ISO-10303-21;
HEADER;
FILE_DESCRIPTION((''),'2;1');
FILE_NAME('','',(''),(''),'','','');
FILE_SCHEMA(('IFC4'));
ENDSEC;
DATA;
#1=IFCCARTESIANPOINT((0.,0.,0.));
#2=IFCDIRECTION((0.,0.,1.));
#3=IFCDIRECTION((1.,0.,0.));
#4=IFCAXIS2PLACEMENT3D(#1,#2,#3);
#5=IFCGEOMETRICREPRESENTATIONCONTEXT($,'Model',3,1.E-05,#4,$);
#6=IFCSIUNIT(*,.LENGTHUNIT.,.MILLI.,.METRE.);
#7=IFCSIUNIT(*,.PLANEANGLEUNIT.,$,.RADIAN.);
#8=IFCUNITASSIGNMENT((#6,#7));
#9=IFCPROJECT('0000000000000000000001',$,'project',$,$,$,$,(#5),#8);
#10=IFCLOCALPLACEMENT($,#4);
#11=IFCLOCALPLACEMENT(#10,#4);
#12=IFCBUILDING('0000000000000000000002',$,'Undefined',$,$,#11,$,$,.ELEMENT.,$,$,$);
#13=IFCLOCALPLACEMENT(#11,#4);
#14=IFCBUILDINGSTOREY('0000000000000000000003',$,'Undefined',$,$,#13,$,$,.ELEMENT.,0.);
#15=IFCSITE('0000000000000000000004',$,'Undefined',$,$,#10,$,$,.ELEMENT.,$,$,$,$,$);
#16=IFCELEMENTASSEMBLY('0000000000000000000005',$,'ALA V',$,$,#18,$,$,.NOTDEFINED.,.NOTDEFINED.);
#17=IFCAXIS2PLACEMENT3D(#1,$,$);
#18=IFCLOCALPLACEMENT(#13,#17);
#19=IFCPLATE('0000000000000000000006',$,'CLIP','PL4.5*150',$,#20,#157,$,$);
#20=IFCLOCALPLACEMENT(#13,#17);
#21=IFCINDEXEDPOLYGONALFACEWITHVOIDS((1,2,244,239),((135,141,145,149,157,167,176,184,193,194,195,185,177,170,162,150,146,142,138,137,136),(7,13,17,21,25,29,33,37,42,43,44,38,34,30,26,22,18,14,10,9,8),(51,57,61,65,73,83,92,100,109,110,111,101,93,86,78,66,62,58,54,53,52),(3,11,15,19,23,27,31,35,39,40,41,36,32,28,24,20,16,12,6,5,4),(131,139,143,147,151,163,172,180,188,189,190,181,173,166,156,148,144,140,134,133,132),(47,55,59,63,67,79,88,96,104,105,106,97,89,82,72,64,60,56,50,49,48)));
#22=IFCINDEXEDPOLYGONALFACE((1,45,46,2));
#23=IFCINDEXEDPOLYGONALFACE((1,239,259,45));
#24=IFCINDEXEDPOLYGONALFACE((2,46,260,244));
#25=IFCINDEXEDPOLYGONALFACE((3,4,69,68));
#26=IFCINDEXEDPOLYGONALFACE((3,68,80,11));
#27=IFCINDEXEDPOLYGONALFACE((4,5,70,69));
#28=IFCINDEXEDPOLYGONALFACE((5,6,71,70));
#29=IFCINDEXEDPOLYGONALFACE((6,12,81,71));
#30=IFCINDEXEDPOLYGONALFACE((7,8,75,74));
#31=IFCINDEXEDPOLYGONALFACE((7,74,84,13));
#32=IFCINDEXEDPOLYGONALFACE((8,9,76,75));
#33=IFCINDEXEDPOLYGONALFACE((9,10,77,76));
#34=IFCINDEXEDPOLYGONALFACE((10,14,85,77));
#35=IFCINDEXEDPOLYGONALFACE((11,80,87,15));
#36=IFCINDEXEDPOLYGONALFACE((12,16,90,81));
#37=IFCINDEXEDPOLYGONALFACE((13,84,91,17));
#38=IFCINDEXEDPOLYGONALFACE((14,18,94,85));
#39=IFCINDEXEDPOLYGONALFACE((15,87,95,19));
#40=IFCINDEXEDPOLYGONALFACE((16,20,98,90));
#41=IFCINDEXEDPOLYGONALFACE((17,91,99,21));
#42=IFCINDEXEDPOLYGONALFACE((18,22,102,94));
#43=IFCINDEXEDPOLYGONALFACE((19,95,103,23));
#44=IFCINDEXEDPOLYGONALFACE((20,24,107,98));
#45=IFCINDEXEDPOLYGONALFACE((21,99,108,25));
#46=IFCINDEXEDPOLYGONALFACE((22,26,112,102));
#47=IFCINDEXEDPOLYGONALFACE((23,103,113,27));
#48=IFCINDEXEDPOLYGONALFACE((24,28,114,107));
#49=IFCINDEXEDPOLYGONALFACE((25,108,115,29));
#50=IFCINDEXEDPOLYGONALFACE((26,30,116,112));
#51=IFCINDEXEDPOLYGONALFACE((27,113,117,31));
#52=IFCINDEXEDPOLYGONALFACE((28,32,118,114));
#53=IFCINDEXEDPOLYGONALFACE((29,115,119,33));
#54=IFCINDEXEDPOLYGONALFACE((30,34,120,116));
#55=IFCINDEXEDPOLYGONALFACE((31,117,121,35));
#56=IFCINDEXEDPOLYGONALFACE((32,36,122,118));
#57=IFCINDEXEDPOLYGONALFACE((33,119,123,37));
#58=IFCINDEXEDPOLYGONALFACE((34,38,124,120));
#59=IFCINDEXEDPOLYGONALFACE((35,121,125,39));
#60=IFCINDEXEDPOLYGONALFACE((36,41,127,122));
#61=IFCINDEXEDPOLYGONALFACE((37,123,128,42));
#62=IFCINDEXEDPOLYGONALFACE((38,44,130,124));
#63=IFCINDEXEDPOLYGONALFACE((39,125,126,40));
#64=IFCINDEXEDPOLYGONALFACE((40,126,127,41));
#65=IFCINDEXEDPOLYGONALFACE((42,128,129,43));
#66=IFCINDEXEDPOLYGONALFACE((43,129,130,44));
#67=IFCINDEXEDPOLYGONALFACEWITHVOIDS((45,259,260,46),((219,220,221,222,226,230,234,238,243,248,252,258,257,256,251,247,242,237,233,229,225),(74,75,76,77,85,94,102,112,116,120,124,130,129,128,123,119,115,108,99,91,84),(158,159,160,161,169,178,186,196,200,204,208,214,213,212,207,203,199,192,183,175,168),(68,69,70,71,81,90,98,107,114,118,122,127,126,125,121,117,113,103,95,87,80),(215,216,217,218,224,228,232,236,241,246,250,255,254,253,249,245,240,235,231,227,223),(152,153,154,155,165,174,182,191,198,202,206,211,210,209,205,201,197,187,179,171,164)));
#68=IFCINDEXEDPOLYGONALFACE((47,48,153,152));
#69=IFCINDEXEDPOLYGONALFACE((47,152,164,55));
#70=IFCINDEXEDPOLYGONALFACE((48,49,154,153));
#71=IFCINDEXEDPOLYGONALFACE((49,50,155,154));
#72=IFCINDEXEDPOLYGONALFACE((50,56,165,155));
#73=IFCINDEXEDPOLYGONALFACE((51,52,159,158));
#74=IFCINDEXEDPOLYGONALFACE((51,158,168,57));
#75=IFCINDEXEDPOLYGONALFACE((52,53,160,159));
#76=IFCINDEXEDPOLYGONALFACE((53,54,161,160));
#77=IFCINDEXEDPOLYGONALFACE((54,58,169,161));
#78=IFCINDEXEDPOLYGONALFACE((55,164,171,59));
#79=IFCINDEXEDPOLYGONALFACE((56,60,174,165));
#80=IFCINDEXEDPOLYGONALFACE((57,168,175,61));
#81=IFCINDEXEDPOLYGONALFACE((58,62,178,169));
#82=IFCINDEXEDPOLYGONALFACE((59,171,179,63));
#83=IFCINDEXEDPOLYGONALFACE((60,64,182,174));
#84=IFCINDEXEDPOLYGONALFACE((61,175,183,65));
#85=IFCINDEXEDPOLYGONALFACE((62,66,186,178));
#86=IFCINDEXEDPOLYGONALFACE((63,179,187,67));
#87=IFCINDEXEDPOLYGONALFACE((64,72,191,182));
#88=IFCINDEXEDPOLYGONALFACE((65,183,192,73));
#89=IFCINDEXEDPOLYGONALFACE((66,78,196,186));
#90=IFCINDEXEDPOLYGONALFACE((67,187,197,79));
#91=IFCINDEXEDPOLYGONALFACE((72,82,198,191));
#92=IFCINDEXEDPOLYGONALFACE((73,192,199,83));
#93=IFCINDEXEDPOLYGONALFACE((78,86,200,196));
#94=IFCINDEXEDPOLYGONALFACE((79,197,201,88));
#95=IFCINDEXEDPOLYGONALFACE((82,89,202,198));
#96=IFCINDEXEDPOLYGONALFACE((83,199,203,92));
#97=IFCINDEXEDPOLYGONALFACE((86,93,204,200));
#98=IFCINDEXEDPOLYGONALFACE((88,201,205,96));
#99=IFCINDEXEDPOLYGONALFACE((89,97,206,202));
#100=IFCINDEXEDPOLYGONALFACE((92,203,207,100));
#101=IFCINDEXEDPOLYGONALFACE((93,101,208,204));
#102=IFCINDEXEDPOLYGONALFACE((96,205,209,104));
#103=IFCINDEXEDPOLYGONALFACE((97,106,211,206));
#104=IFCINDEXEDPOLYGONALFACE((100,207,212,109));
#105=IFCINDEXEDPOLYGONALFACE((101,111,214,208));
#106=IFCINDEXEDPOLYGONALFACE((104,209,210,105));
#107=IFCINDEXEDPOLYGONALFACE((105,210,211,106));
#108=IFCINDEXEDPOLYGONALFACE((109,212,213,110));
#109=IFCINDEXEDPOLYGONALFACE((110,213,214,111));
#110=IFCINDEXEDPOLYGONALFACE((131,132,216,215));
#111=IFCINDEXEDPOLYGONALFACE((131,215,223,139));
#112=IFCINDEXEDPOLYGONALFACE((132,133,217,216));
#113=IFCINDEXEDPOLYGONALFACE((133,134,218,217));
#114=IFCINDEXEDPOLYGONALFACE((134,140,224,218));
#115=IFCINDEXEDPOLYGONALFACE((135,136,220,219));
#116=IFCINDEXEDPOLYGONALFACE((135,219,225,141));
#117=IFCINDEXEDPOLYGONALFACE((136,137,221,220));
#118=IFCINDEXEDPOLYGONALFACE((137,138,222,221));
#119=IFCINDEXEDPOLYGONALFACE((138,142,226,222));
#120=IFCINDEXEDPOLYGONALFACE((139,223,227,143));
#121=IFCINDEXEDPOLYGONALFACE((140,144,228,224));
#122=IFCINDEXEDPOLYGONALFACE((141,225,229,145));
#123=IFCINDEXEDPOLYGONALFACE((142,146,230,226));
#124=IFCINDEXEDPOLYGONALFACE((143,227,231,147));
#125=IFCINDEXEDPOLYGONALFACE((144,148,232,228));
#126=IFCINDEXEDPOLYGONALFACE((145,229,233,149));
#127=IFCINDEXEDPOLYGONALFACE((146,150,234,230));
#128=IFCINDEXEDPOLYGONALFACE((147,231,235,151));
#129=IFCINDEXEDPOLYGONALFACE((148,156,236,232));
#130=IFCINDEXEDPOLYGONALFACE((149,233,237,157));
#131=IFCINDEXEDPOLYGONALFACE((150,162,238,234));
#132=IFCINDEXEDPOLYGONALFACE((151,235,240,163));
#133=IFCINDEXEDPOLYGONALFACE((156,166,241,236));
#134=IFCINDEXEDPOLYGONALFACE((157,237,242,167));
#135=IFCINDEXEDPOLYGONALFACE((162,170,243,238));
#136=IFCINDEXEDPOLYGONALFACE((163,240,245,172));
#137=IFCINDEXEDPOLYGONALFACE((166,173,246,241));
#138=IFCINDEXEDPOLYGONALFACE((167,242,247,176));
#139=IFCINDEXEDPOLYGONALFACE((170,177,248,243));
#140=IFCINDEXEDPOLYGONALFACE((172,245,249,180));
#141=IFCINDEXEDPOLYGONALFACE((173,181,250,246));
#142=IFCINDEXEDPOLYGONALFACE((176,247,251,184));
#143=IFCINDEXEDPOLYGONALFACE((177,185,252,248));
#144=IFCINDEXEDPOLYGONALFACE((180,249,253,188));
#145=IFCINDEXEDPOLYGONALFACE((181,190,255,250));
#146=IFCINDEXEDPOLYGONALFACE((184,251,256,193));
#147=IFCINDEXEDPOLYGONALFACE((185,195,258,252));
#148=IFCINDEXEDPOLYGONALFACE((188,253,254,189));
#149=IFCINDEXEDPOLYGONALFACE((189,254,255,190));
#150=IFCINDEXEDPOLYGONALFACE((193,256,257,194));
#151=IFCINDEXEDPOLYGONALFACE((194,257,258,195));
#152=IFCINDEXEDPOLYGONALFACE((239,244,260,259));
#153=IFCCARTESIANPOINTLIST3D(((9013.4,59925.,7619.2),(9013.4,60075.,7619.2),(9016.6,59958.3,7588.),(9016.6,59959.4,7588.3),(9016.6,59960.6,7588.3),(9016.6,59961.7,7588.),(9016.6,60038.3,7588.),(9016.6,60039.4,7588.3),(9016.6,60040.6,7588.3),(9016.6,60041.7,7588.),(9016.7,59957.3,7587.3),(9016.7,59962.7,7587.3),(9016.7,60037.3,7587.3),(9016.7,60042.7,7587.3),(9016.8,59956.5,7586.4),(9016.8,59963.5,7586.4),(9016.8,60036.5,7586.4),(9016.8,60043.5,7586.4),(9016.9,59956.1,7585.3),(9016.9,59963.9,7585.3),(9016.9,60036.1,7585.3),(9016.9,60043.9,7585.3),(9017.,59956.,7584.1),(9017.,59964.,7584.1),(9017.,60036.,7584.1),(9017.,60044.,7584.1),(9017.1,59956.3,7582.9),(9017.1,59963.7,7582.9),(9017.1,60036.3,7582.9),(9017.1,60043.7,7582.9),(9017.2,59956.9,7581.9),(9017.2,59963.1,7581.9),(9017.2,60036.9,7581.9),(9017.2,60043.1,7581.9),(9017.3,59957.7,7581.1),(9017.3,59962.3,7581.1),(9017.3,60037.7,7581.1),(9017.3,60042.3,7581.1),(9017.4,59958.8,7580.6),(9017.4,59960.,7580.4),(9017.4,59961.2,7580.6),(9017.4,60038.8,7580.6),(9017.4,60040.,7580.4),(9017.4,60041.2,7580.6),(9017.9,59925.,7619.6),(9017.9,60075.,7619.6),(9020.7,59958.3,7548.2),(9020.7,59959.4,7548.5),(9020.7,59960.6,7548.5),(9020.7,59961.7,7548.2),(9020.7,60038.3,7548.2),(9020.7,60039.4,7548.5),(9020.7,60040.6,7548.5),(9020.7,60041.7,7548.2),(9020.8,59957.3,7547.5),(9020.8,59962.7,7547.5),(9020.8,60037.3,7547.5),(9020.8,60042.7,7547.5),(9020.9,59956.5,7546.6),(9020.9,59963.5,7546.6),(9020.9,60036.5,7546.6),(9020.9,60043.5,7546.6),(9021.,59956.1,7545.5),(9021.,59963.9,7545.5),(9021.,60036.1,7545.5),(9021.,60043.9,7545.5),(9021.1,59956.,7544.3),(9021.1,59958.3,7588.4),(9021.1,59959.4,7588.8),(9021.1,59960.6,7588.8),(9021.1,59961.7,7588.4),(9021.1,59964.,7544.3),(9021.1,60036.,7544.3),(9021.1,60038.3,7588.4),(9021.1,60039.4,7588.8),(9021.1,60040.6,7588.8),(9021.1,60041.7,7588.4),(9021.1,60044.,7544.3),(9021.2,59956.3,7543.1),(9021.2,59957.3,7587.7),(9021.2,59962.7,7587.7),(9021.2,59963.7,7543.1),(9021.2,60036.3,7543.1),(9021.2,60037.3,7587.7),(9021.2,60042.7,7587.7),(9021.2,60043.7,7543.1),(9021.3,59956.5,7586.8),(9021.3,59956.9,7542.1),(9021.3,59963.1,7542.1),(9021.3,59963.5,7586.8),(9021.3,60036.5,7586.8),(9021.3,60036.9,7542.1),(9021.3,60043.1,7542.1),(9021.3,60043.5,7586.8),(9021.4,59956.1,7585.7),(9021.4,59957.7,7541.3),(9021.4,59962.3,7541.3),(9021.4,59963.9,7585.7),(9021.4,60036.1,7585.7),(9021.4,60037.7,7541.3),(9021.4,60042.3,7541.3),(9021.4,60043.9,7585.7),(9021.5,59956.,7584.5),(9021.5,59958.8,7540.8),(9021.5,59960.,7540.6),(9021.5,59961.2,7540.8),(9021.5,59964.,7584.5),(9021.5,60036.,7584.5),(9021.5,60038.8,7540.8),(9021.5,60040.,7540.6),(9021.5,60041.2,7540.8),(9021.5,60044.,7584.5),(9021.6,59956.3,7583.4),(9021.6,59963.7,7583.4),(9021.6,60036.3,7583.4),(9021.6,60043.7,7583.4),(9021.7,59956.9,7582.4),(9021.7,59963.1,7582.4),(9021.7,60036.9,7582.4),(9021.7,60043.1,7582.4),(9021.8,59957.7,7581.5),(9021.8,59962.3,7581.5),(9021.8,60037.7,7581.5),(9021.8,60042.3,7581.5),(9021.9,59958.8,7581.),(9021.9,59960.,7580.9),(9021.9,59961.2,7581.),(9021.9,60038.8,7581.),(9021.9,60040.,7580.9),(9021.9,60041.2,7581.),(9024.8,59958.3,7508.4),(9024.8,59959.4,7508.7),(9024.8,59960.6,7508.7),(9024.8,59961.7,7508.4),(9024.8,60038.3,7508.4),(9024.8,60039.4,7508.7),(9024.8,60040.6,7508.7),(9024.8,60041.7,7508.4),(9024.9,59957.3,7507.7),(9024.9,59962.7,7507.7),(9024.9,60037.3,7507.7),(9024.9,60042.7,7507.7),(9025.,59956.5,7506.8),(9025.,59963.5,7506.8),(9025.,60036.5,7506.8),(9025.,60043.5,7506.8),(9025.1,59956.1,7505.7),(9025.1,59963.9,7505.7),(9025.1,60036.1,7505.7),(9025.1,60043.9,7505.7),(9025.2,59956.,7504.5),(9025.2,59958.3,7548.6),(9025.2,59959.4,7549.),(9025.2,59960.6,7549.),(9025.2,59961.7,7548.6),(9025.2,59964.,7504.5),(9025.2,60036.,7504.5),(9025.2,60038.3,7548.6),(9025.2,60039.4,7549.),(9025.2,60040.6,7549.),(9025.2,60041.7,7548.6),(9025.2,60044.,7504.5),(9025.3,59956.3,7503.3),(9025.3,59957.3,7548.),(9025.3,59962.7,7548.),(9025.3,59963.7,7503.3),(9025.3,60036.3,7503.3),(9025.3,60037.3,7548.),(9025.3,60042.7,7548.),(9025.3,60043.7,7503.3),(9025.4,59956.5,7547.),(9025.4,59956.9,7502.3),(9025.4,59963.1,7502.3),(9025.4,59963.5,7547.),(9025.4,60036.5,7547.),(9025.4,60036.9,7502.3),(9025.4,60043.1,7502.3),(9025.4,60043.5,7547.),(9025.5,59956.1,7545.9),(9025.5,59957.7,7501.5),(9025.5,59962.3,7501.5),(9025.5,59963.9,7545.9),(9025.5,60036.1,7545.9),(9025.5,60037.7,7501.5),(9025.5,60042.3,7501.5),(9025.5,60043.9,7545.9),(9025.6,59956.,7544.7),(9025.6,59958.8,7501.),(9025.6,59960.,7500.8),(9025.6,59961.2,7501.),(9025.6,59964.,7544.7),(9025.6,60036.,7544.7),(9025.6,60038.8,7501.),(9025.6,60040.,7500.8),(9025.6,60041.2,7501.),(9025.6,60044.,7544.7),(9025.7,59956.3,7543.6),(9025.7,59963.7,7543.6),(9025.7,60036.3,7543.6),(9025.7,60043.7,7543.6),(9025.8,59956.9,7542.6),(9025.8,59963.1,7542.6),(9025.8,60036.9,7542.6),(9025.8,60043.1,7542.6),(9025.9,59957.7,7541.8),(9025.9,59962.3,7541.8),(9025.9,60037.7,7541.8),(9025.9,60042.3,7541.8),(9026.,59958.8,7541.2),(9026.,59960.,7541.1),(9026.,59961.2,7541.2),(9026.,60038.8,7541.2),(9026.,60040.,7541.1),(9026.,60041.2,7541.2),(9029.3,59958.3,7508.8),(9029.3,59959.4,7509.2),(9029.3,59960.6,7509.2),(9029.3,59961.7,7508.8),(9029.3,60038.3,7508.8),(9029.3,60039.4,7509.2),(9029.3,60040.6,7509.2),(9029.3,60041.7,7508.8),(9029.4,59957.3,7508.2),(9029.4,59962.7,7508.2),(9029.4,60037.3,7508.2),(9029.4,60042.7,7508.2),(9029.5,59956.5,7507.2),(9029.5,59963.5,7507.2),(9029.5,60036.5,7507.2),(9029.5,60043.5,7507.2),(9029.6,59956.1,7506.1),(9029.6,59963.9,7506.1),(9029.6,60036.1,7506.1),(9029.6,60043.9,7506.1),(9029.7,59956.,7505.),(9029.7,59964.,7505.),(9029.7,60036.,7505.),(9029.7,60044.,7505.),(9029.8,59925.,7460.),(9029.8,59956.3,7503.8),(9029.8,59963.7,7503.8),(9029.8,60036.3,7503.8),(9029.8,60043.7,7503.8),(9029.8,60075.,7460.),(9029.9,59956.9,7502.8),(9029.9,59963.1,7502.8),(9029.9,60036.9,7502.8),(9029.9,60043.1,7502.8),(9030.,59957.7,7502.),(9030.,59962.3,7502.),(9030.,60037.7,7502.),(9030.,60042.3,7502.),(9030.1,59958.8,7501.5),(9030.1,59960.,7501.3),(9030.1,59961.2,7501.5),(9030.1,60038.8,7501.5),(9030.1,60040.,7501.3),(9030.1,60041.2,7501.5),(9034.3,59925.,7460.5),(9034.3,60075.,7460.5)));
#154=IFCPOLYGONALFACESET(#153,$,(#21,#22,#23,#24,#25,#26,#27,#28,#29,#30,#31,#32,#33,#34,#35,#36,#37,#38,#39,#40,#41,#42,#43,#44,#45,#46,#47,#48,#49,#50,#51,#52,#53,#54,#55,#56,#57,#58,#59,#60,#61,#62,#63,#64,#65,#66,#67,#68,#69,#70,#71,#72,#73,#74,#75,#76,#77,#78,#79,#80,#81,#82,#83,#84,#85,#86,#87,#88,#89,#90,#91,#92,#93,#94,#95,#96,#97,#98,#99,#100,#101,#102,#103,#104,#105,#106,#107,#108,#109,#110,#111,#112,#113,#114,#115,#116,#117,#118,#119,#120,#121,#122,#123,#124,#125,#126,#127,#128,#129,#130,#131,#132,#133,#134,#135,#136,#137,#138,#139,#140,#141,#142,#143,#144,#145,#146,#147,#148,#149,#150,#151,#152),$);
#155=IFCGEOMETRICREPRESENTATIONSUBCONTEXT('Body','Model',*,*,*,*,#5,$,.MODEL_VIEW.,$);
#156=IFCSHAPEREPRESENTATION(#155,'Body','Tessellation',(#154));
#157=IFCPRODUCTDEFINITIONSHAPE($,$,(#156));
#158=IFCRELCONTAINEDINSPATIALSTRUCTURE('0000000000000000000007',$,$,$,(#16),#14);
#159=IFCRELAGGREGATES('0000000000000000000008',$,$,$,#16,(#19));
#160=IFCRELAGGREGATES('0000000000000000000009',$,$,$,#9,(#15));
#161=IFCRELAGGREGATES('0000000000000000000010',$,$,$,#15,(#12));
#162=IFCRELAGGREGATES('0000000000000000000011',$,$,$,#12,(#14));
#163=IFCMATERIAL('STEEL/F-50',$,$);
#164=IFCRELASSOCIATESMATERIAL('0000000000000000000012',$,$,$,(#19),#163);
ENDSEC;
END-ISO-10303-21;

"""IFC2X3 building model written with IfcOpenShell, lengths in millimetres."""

from ifc_helpers import new_model, si_unit, frame, origin_with_axes, origin_2d_with_axis, place, context, subcontext, project, spatial, polyline, circle, outline, extrude, source, transform, mapped, material, element, aggregate, save


model = new_model("IFC2X3")

# Units and contexts
model_context = context("Model", 3, precision=1e-05, world=origin_with_axes())
body_context = subcontext(model_context, "Body", "Model", "MODEL_VIEW")
ifc_project = project(units=[si_unit("LENGTHUNIT", "METRE", prefix="MILLI"), si_unit("PLANEANGLEUNIT", "RADIAN")], contexts=[model_context])

# Site, building, storey
site_placement = place(None, origin_with_axes())
site = spatial("IfcSite", under=ifc_project, at=site_placement, Name="Undefined", CompositionType="ELEMENT")
building_placement = place(site_placement, origin_with_axes())
building = spatial("IfcBuilding", under=site, at=building_placement, Name="Undefined", CompositionType="ELEMENT")
storey_placement = place(building_placement, origin_with_axes())
storey = spatial("IfcBuildingStorey", under=building, at=storey_placement, Name="Undefined", CompositionType="ELEMENT", Elevation=0.0)

# Element assembly
assembly_1_placement = place(storey_placement, origin_with_axes())
assembly_1 = element("IfcElementAssembly", 1, at=assembly_1_placement, inside=storey, Name="ALA V", AssemblyPlace="NOTDEFINED", PredefinedType="NOTDEFINED")
ifc_material_1 = material(Name="STEEL/F-50")

# Plate, openings
shared_shape_1 = source(origin_with_axes(), body_context, "Body", "SweptSolid", [
    extrude(circle(Radius=4.0, at=origin_2d_with_axis()), frame((0.0, -4.6, 0.0), z_axis=(0.0, 1.0, 0.0), x_axis=(1.0, 0.0, 0.0)), (0.0, 0.0, 1.0), 4.7),
])
plate_1_placement = place(assembly_1_placement, frame((9015.6, 59925.0, 7619.4), z_axis=(0.994727, 0.0, 0.102562), x_axis=(0.102562, 0.0, -0.994727)))
plate_1 = element("IfcPlate", 2, at=plate_1_placement, material=ifc_material_1, Name="CLIP", Description="PL4.5*150", context=body_context, shape_type="SweptSolid", body=[
    extrude(outline(polyline([(0.0, 0.0), (160.0, 0.0), (160.0, 150.0), (0.0, 150.0), (0.0, 0.0)])), frame((0.0, 0.0, -2.2), z_axis=(0.0, 0.0, 1.0), x_axis=(1.0, 0.0, 0.0)), (0.0, 0.0, 1.0), 4.5),
])
opening_1_placement = place(assembly_1_placement, frame((9017.0, 60040.0, 7584.4), z_axis=(0.0, 1.0, 0.0), x_axis=(0.102562, 0.0, -0.994727)))
element("IfcOpeningElement", 3, at=opening_1_placement, cuts=plate_1, ObjectType="Opening", context=body_context, shape_type="MappedRepresentation", body=[
    mapped(shared_shape_1, transform((0.0, 0.0, 0.0))),
    mapped(shared_shape_1, transform((40.0, 0.0, 0.0))),
    mapped(shared_shape_1, transform((80.0, 0.0, 0.0))),
])
opening_2_placement = place(assembly_1_placement, frame((9017.0, 59960.0, 7584.4), z_axis=(0.0, 1.0, 0.0), x_axis=(0.102562, 0.0, -0.994727)))
element("IfcOpeningElement", 4, at=opening_2_placement, cuts=plate_1, ObjectType="Opening", context=body_context, shape_type="MappedRepresentation", body=[
    mapped(shared_shape_1, transform((0.0, 0.0, 0.0))),
    mapped(shared_shape_1, transform((40.0, 0.0, 0.0))),
    mapped(shared_shape_1, transform((80.0, 0.0, 0.0))),
])

aggregate(assembly_1, [plate_1])

save(model, "model.ifc")
